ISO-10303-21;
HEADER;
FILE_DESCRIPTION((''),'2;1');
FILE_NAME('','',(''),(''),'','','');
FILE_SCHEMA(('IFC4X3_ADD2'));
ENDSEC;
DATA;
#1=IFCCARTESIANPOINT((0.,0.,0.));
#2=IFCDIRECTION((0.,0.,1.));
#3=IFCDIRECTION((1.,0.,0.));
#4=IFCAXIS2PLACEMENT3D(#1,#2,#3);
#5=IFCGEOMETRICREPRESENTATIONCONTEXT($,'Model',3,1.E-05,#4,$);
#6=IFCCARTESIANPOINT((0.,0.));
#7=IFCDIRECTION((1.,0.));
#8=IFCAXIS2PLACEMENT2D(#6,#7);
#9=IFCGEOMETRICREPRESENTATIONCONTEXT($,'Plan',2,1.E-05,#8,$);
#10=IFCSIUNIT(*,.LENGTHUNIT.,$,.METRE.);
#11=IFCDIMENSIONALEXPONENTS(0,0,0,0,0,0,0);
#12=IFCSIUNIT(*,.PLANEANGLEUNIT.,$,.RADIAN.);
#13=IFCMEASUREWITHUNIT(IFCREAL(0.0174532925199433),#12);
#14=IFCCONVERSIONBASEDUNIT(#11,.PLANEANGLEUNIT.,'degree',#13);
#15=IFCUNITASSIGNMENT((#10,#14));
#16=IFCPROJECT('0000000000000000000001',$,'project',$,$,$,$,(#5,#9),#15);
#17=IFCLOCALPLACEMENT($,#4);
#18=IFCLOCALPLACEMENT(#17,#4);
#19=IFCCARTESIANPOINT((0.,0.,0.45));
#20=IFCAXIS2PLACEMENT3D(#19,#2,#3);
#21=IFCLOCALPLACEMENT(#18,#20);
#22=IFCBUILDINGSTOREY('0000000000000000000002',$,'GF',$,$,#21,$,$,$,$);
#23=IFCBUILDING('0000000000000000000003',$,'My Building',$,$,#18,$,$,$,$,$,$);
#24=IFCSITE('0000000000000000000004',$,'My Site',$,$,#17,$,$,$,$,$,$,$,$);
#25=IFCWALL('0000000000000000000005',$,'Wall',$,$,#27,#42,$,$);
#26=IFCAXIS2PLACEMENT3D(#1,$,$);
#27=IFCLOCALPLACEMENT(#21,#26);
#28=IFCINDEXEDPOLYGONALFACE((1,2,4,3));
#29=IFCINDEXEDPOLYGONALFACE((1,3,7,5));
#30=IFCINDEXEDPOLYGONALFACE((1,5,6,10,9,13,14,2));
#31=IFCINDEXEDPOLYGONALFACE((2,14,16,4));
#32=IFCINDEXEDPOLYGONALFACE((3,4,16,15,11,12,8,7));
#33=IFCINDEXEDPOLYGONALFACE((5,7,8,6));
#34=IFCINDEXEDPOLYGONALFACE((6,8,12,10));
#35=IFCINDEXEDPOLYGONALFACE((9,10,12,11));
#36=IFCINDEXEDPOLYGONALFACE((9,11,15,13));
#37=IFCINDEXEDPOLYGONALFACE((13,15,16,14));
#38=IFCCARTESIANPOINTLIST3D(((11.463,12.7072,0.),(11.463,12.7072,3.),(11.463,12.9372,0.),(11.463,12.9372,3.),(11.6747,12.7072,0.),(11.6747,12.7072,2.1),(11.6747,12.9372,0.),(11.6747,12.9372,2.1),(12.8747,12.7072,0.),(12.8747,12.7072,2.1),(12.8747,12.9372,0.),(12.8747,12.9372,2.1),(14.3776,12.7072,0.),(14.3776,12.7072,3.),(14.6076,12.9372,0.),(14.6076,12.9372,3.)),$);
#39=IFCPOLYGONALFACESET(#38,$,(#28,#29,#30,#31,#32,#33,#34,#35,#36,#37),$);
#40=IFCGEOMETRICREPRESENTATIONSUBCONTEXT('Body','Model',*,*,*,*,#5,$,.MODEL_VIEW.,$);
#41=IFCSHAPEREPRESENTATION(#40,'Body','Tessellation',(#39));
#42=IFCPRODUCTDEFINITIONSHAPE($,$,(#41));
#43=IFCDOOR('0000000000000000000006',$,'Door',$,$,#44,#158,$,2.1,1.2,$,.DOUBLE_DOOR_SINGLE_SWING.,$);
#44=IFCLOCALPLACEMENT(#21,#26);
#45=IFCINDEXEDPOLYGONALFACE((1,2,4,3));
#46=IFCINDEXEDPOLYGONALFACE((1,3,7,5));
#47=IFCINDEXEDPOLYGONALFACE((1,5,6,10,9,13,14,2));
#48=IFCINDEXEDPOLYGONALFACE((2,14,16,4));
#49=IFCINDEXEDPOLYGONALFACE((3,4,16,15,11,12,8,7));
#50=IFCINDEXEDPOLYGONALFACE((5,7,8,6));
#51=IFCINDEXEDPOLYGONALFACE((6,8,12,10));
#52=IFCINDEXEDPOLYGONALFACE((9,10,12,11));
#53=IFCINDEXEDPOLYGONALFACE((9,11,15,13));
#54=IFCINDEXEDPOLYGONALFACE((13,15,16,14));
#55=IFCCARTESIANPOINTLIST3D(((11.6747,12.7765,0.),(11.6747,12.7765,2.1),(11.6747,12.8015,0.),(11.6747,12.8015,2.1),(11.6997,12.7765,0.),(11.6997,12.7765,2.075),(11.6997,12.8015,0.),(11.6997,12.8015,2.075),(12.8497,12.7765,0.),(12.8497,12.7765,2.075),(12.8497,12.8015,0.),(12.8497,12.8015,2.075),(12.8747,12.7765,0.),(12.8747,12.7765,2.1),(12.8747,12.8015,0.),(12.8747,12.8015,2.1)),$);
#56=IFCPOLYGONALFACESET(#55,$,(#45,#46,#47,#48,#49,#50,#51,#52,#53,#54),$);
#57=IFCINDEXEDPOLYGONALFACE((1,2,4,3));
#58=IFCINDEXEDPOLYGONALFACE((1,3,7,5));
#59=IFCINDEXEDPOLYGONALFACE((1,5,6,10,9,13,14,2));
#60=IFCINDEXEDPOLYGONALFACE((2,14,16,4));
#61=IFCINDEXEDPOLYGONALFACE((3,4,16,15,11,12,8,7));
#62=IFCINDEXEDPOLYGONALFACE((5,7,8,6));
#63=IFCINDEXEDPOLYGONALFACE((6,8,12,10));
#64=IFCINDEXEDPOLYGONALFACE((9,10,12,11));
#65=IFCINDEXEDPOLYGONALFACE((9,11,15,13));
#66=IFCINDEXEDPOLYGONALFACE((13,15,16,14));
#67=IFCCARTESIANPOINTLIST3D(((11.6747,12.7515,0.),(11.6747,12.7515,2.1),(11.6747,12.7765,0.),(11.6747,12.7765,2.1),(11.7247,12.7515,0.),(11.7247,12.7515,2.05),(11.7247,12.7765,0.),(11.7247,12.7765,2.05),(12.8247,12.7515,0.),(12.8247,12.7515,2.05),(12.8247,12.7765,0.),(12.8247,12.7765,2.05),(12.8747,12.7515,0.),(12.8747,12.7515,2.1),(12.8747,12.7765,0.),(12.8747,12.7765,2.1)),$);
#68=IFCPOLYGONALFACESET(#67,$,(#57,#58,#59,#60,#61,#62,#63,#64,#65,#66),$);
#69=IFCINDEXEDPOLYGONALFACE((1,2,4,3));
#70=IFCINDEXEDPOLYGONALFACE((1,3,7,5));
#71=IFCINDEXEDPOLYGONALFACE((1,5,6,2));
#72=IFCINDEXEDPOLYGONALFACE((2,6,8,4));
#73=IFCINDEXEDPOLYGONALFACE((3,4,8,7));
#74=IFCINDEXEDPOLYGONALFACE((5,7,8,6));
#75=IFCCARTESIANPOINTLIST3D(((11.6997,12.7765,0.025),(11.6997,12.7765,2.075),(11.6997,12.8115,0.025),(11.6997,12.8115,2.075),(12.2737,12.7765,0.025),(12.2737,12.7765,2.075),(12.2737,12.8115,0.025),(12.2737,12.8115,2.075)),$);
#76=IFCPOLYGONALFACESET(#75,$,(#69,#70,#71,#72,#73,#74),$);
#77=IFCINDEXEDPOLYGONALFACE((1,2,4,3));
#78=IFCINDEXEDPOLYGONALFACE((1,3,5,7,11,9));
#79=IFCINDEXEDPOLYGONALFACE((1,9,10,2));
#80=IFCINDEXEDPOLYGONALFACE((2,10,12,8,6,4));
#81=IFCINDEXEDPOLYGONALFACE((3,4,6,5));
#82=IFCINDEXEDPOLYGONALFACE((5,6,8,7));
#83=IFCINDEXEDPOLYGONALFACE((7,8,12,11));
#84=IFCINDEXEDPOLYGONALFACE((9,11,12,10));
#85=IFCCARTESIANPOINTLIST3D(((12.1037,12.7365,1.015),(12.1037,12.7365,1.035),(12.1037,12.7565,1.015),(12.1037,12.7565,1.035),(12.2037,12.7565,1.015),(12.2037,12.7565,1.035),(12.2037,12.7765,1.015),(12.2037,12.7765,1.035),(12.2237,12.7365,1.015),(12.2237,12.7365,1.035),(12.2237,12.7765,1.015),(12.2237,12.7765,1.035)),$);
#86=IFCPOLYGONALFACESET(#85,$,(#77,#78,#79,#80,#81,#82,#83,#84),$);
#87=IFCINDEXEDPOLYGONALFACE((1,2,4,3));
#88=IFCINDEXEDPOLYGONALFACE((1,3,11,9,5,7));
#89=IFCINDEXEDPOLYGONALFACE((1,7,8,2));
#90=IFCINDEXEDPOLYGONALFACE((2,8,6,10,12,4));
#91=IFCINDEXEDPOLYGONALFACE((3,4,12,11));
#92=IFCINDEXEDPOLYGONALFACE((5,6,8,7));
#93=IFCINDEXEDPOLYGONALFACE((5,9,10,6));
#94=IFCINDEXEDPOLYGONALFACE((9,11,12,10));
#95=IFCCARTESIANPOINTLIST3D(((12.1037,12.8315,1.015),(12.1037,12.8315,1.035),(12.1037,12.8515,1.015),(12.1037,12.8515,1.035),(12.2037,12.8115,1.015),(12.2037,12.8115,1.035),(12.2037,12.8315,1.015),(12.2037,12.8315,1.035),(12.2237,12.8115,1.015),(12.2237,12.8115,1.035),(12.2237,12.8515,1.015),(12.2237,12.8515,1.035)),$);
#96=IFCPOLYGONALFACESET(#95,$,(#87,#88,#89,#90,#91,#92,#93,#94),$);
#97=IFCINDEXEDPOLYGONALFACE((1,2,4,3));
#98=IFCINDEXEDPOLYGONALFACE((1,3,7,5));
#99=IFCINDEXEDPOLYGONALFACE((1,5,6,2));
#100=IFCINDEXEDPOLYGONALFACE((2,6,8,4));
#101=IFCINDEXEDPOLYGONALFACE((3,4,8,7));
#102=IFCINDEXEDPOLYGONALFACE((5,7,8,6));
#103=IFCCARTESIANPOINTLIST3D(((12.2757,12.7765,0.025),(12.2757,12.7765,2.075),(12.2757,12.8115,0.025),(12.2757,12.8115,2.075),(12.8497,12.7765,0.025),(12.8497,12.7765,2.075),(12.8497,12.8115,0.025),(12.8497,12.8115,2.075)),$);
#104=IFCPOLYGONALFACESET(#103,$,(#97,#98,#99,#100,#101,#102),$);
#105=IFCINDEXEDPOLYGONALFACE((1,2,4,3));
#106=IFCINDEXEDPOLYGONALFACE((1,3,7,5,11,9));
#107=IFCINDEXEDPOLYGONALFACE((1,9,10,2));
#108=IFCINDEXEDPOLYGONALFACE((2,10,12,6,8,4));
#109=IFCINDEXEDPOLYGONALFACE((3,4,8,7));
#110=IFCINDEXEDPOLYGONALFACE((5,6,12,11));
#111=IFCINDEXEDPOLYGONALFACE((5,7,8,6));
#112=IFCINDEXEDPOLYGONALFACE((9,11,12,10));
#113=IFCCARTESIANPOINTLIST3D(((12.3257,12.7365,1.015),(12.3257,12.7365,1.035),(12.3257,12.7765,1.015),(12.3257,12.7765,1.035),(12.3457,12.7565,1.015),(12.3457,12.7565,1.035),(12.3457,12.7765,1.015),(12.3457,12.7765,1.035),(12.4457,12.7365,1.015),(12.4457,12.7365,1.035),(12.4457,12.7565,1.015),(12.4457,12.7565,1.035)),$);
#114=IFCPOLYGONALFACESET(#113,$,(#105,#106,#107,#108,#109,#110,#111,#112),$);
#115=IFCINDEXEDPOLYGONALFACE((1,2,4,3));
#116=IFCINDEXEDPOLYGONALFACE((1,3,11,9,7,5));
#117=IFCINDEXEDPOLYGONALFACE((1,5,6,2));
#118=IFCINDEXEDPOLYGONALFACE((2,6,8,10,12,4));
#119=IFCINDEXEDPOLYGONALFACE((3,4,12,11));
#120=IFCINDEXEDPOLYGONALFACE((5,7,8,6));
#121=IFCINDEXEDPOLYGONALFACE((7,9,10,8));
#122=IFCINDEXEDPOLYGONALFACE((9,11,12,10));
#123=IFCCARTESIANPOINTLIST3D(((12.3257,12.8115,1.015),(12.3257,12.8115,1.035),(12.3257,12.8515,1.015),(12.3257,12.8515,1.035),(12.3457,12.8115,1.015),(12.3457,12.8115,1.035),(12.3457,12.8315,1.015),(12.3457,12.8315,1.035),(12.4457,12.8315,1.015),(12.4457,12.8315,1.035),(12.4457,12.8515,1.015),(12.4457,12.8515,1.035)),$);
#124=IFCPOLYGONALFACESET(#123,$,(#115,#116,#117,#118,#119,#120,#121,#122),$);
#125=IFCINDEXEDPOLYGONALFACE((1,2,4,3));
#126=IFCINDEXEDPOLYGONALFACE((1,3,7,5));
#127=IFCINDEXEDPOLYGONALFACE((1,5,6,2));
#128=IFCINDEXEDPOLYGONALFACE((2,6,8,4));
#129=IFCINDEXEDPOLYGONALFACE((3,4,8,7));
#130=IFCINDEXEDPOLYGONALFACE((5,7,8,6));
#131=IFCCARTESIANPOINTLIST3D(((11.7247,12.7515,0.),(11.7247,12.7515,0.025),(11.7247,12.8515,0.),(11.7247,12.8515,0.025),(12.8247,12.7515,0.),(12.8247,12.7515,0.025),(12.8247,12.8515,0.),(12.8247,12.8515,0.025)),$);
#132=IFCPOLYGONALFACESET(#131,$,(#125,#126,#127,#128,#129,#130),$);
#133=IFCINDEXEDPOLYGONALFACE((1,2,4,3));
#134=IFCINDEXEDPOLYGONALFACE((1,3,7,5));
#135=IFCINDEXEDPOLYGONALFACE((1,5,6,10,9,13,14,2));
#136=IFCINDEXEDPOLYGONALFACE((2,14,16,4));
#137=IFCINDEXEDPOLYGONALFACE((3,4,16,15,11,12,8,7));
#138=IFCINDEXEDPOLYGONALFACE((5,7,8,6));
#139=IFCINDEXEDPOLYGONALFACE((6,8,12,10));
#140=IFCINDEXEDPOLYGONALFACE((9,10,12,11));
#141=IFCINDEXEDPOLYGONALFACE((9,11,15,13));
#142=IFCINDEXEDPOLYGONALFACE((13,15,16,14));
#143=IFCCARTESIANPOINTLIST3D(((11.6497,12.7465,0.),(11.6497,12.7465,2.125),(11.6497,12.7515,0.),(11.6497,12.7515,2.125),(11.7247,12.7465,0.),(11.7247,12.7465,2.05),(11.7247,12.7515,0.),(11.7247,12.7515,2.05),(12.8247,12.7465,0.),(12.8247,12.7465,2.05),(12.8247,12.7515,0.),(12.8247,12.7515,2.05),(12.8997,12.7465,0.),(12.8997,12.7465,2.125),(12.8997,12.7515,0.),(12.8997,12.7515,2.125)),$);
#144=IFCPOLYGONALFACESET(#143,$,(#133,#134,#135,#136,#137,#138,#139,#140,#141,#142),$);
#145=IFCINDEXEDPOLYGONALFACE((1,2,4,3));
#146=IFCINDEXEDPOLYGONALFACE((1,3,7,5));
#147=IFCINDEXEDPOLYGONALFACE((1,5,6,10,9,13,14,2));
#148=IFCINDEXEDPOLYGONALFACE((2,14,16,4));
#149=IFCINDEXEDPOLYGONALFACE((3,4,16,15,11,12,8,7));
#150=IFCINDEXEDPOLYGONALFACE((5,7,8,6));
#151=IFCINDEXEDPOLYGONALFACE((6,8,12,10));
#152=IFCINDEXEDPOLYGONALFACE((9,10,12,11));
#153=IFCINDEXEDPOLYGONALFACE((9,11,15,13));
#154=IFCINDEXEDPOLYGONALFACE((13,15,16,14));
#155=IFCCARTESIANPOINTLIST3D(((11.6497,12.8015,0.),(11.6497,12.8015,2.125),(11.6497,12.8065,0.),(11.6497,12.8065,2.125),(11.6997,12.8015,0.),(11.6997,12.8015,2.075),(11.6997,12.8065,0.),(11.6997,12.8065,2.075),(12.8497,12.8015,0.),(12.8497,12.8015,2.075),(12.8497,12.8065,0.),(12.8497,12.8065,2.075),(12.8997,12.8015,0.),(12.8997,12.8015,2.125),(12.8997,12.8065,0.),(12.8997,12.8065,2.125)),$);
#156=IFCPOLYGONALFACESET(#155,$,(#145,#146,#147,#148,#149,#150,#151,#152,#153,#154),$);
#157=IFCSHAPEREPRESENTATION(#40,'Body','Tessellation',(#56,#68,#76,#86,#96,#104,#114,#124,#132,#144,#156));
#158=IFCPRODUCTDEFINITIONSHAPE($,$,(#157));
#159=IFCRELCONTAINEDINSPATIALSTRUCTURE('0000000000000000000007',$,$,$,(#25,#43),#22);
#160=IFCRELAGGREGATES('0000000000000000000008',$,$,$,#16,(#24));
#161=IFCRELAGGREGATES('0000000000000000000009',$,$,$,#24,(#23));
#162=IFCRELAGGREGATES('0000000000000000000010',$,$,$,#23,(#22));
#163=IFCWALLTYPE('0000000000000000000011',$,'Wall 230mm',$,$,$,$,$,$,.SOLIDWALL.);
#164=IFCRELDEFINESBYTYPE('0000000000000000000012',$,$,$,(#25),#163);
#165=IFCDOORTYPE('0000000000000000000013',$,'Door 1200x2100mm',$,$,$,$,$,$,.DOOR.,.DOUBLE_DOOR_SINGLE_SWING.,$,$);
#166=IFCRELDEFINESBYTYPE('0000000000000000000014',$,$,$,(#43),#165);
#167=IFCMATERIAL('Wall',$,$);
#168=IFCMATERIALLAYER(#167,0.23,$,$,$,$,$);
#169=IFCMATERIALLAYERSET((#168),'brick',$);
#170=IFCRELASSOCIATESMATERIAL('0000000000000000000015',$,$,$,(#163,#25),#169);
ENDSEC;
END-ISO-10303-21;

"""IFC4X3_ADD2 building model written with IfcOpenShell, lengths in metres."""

from ifc_helpers import new_model, entity, si_unit, converted_unit, frame, origin_with_axes, origin_2d_with_axis, place, context, subcontext, project, spatial, line, indexed_curve, outline, extrude, clip, halfspace, shape, source, transform, mapped, material, layer, layer_set, layer_usage, type_object, type_shapes, element, fill, save


model = new_model("IFC4X3_ADD2")

# Units and contexts
model_context = context("Model", 3, precision=1e-05, world=origin_with_axes())
plan_context = context("Plan", 2, precision=1e-05, world=origin_2d_with_axis())
body_context_1 = subcontext(model_context, "Body", "Model", "MODEL_VIEW")
body_context_2 = subcontext(plan_context, "Body", "Plan", "PLAN_VIEW")
ifc_project = project(units=[si_unit("LENGTHUNIT", "METRE"), converted_unit("PLANEANGLEUNIT", "degree", entity("IfcReal", 0.0174532925199433), si_unit("PLANEANGLEUNIT", "RADIAN"), dimensions=[0, 0, 0, 0, 0, 0, 0])], contexts=[model_context, plan_context])

# Site, building, storey
site_placement = place(None, origin_with_axes())
site = spatial("IfcSite", under=ifc_project, at=site_placement, Name="My Site")
building_placement = place(site_placement, origin_with_axes())
building = spatial("IfcBuilding", under=site, at=building_placement, Name="My Building")
storey_placement = place(building_placement, frame((0.0, 0.0, 0.45), z_axis=(0.0, 0.0, 1.0), x_axis=(1.0, 0.0, 0.0)))
storey = spatial("IfcBuildingStorey", under=building, at=storey_placement, Name="GF")

# Shared definitions
ifc_material_1 = material(Name="Wall")
ifc_layer = layer(ifc_material_1, 0.23)
ifc_layer_set = layer_set([ifc_layer], Name="brick")
wall_type = type_object("IfcWallType", Name="Wall 230mm", PredefinedType="SOLIDWALL", material=ifc_layer_set)

# Wall, opening, door
shared_shape_1 = source(origin_with_axes(), body_context_1, "Body", "SweptSolid", [
    extrude(outline(indexed_curve([(0.0, 0.0), (1.2, 0.0), (1.2, 2.1), (0.0, 2.1)], segments=[line(1, 2, 3, 4, 1)])), frame((0.0, -0.6, 0.0), z_axis=(0.0, -1.0, 0.0), x_axis=(1.0, 0.0, 0.0)), (0.0, 0.0, -1.0), 1.2),
])
door_type_1 = type_object("IfcDoorType", Name="Door 1200x2100mm", OperationType="DOUBLE_DOOR_SINGLE_SWING", PredefinedType="DOOR")
shared_shape_2 = source(origin_with_axes(), body_context_1, "Body", "SweptSolid", [
    extrude(outline(indexed_curve([(0.0, 0.0), (0.0, 2.1), (1.2, 2.1), (1.2, 0.0), (1.175, 0.0), (1.175, 2.075), (0.025, 2.075), (0.025, 0.0)], segments=[line(1, 2, 3, 4, 5, 6, 7, 8, 1)])), frame((0.0, 0.025, 0.0), z_axis=(0.0, -1.0, 0.0), x_axis=(1.0, 0.0, 0.0)), (0.0, 0.0, -1.0), 0.025),
    extrude(outline(indexed_curve([(0.0, 0.0), (0.0, 2.1), (1.2, 2.1), (1.2, 0.0), (1.15, 0.0), (1.15, 2.05), (0.05, 2.05), (0.05, 0.0)], segments=[line(1, 2, 3, 4, 5, 6, 7, 8, 1)])), frame((0.0, 0.0, 0.0), z_axis=(0.0, -1.0, 0.0), x_axis=(1.0, 0.0, 0.0)), (0.0, 0.0, -1.0), 0.025),
    extrude(outline(indexed_curve([(0.0, 0.0), (0.574, 0.0), (0.574, 0.035), (0.0, 0.035)], segments=[line(1, 2, 3, 4, 1)])), frame((0.025, 0.025, 0.025), z_axis=(0.0, 0.0, 1.0), x_axis=(1.0, 0.0, 0.0)), (0.0, 0.0, 1.0), 2.05),
    extrude(outline(indexed_curve([(0.0, 0.0), (0.0, -0.04), (-0.12, -0.04), (-0.12, -0.02), (-0.02, -0.02), (-0.02, 0.0)], segments=[line(1, 2, 3, 4, 5, 6, 1)])), frame((0.549, 0.025, 1.015), z_axis=(0.0, 0.0, 1.0), x_axis=(1.0, 0.0, 0.0)), (0.0, 0.0, 1.0), 0.02),
    extrude(outline(indexed_curve([(0.0, 0.0), (0.0, 0.04), (-0.12, 0.04), (-0.12, 0.02), (-0.02, 0.02), (-0.02, 0.0)], segments=[line(1, 2, 3, 4, 5, 6, 1)])), frame((0.549, 0.06, 1.015), z_axis=(0.0, 0.0, 1.0), x_axis=(1.0, 0.0, 0.0)), (0.0, 0.0, 1.0), 0.02),
    extrude(outline(indexed_curve([(0.0, 0.0), (-0.574, 0.0), (-0.574, 0.035), (0.0, 0.035)], segments=[line(1, 2, 3, 4, 1)])), frame((1.175, 0.025, 0.025), z_axis=(0.0, 0.0, 1.0), x_axis=(1.0, 0.0, 0.0)), (0.0, 0.0, 1.0), 2.05),
    extrude(outline(indexed_curve([(0.0, 0.0), (0.0, -0.04), (0.12, -0.04), (0.12, -0.02), (0.02, -0.02), (0.02, 0.0)], segments=[line(1, 2, 3, 4, 5, 6, 1)])), frame((0.651, 0.025, 1.015), z_axis=(0.0, 0.0, 1.0), x_axis=(1.0, 0.0, 0.0)), (0.0, 0.0, 1.0), 0.02),
    extrude(outline(indexed_curve([(0.0, 0.0), (0.0, 0.04), (0.12, 0.04), (0.12, 0.02), (0.02, 0.02), (0.02, 0.0)], segments=[line(1, 2, 3, 4, 5, 6, 1)])), frame((0.651, 0.06, 1.015), z_axis=(0.0, 0.0, 1.0), x_axis=(1.0, 0.0, 0.0)), (0.0, 0.0, 1.0), 0.02),
    extrude(outline(indexed_curve([(0.0, 0.0), (1.1, 0.0), (1.1, 0.1), (0.0, 0.1)], segments=[line(1, 2, 3, 4, 1)])), frame((0.05, 0.0, 0.0), z_axis=(0.0, 0.0, 1.0), x_axis=(1.0, 0.0, 0.0)), (0.0, 0.0, 1.0), 0.025),
    extrude(outline(indexed_curve([(0.0, 0.0), (0.0, 2.125), (1.25, 2.125), (1.25, 0.0), (1.175, 0.0), (1.175, 2.05), (0.075, 2.05), (0.075, 0.0)], segments=[line(1, 2, 3, 4, 5, 6, 7, 8, 1)])), frame((-0.025, -0.005, 0.0), z_axis=(0.0, -1.0, 0.0), x_axis=(1.0, 0.0, 0.0)), (0.0, 0.0, -1.0), 0.005),
    extrude(outline(indexed_curve([(0.0, 0.0), (0.0, 2.125), (1.25, 2.125), (1.25, 0.0), (1.2, 0.0), (1.2, 2.075), (0.05, 2.075), (0.05, 0.0)], segments=[line(1, 2, 3, 4, 5, 6, 7, 8, 1)])), frame((-0.025, 0.05, 0.0), z_axis=(0.0, -1.0, 0.0), x_axis=(1.0, 0.0, 0.0)), (0.0, 0.0, -1.0), 0.005),
])
shared_shape_3 = source(origin_with_axes(), body_context_2, "Body", "Curve2D", [
    entity("IfcIndexedPolyCurve", entity("IfcCartesianPointList2D", [[0.0, 0.0], [0.0, 0.05], [0.025, 0.05], [0.025, 0.025], [0.05, 0.025], [0.05, 0.0]]), [entity("IfcLineIndex", [1, 2, 3, 4, 5, 6, 1])]),
    entity("IfcIndexedPolyCurve", entity("IfcCartesianPointList2D", [[1.2, 0.0], [1.2, 0.05], [1.175, 0.05], [1.175, 0.025], [1.15, 0.025], [1.15, 0.0]]), [entity("IfcLineIndex", [1, 2, 3, 4, 5, 6, 1])]),
    entity("IfcTrimmedCurve", entity("IfcEllipse", entity("IfcAxis2Placement2D", entity("IfcCartesianPoint", [0.06, 0.05]), entity("IfcDirection", [1.0, 0.0])), 0.54, 0.575), [entity("IfcCartesianPoint", [0.6, 0.05])], [entity("IfcCartesianPoint", [0.06, 0.625])], True, "CARTESIAN"),
    entity("IfcIndexedPolyCurve", entity("IfcCartesianPointList2D", [[0.025, 0.05], [0.06, 0.05], [0.06, 0.625], [0.025, 0.625]]), [entity("IfcLineIndex", [1, 2, 3, 4, 1])]),
    entity("IfcTrimmedCurve", entity("IfcEllipse", entity("IfcAxis2Placement2D", entity("IfcCartesianPoint", [1.14, 0.05]), entity("IfcDirection", [1.0, 0.0])), 0.54, 0.575), [entity("IfcCartesianPoint", [1.14, 0.625])], [entity("IfcCartesianPoint", [0.6, 0.05])], True, "CARTESIAN"),
    entity("IfcIndexedPolyCurve", entity("IfcCartesianPointList2D", [[1.175, 0.05], [1.14, 0.05], [1.14, 0.625], [1.175, 0.625]]), [entity("IfcLineIndex", [1, 2, 3, 4, 1])]),
])
type_shapes(door_type_1, [shared_shape_2, shared_shape_3])
ifc_layer_usage_1 = layer_usage(ifc_layer_set, "AXIS2", "POSITIVE", 0.0)
wall_1_placement = place(storey_placement, frame((11.463, 12.7072, 0.0), z_axis=(0.0, 0.0, 1.0), x_axis=(1.0, 0.0, 0.0)))
wall_1 = element("IfcWall", 1, at=wall_1_placement, inside=storey, type_object=wall_type, material=ifc_layer_usage_1, Name="Wall", context=body_context_1, shape_type="Clipping", body=[
    clip(extrude(outline(indexed_curve([(0.0, 0.0), (0.0, 0.23), (3.1446, 0.23), (3.1446, 0.0), (0.0, 0.0)], self_intersect=False)), origin_with_axes(), (0.0, 0.0, 1.0), 3.0), halfspace(frame((2.9146, 0.0, -0.45), z_axis=(0.689999, -0.689999, 0.0), x_axis=(-0.707107, -0.707107, 0.0)), False)),
])
opening_1_placement = place(wall_1_placement, frame((0.2117, 0.0443, 0.0), z_axis=(0.0, 0.0, 1.0), x_axis=(1.0, 0.0, 0.0)))
opening_1 = element("IfcOpeningElement", 2, at=opening_1_placement, cuts=wall_1, PredefinedType="OPENING", context=body_context_1, shape_type="MappedRepresentation", body=[
    mapped(shared_shape_1, transform((0.0, 0.0, 0.0), x_axis=(1.0, 0.0, 0.0), y_axis=(0.0, 1.0, 0.0), z_axis=(0.0, 0.0, 1.0), scale=1.0)),
])
door_1_placement = place(opening_1_placement, origin_with_axes())
door_1 = element("IfcDoor", 3, at=door_1_placement, inside=storey, type_object=door_type_1, Name="Door", OperationType="DOUBLE_DOOR_SINGLE_SWING", OverallHeight=2.1, OverallWidth=1.2, shapes=[
    shape(body_context_1, "Body", "MappedRepresentation", [mapped(shared_shape_2, transform((0.0, 0.0, 0.0), x_axis=(1.0, 0.0, 0.0), y_axis=(0.0, 1.0, 0.0), z_axis=(0.0, 0.0, 1.0), scale=1.0))]),
    shape(body_context_2, "Body", "MappedRepresentation", [mapped(shared_shape_3, transform((0.0, 0.0, 0.0), x_axis=(1.0, 0.0, 0.0), y_axis=(0.0, 1.0, 0.0), z_axis=(0.0, 0.0, 1.0), scale=1.0))]),
])
fill(opening_1, door_1)

save(model, "model.ifc")
